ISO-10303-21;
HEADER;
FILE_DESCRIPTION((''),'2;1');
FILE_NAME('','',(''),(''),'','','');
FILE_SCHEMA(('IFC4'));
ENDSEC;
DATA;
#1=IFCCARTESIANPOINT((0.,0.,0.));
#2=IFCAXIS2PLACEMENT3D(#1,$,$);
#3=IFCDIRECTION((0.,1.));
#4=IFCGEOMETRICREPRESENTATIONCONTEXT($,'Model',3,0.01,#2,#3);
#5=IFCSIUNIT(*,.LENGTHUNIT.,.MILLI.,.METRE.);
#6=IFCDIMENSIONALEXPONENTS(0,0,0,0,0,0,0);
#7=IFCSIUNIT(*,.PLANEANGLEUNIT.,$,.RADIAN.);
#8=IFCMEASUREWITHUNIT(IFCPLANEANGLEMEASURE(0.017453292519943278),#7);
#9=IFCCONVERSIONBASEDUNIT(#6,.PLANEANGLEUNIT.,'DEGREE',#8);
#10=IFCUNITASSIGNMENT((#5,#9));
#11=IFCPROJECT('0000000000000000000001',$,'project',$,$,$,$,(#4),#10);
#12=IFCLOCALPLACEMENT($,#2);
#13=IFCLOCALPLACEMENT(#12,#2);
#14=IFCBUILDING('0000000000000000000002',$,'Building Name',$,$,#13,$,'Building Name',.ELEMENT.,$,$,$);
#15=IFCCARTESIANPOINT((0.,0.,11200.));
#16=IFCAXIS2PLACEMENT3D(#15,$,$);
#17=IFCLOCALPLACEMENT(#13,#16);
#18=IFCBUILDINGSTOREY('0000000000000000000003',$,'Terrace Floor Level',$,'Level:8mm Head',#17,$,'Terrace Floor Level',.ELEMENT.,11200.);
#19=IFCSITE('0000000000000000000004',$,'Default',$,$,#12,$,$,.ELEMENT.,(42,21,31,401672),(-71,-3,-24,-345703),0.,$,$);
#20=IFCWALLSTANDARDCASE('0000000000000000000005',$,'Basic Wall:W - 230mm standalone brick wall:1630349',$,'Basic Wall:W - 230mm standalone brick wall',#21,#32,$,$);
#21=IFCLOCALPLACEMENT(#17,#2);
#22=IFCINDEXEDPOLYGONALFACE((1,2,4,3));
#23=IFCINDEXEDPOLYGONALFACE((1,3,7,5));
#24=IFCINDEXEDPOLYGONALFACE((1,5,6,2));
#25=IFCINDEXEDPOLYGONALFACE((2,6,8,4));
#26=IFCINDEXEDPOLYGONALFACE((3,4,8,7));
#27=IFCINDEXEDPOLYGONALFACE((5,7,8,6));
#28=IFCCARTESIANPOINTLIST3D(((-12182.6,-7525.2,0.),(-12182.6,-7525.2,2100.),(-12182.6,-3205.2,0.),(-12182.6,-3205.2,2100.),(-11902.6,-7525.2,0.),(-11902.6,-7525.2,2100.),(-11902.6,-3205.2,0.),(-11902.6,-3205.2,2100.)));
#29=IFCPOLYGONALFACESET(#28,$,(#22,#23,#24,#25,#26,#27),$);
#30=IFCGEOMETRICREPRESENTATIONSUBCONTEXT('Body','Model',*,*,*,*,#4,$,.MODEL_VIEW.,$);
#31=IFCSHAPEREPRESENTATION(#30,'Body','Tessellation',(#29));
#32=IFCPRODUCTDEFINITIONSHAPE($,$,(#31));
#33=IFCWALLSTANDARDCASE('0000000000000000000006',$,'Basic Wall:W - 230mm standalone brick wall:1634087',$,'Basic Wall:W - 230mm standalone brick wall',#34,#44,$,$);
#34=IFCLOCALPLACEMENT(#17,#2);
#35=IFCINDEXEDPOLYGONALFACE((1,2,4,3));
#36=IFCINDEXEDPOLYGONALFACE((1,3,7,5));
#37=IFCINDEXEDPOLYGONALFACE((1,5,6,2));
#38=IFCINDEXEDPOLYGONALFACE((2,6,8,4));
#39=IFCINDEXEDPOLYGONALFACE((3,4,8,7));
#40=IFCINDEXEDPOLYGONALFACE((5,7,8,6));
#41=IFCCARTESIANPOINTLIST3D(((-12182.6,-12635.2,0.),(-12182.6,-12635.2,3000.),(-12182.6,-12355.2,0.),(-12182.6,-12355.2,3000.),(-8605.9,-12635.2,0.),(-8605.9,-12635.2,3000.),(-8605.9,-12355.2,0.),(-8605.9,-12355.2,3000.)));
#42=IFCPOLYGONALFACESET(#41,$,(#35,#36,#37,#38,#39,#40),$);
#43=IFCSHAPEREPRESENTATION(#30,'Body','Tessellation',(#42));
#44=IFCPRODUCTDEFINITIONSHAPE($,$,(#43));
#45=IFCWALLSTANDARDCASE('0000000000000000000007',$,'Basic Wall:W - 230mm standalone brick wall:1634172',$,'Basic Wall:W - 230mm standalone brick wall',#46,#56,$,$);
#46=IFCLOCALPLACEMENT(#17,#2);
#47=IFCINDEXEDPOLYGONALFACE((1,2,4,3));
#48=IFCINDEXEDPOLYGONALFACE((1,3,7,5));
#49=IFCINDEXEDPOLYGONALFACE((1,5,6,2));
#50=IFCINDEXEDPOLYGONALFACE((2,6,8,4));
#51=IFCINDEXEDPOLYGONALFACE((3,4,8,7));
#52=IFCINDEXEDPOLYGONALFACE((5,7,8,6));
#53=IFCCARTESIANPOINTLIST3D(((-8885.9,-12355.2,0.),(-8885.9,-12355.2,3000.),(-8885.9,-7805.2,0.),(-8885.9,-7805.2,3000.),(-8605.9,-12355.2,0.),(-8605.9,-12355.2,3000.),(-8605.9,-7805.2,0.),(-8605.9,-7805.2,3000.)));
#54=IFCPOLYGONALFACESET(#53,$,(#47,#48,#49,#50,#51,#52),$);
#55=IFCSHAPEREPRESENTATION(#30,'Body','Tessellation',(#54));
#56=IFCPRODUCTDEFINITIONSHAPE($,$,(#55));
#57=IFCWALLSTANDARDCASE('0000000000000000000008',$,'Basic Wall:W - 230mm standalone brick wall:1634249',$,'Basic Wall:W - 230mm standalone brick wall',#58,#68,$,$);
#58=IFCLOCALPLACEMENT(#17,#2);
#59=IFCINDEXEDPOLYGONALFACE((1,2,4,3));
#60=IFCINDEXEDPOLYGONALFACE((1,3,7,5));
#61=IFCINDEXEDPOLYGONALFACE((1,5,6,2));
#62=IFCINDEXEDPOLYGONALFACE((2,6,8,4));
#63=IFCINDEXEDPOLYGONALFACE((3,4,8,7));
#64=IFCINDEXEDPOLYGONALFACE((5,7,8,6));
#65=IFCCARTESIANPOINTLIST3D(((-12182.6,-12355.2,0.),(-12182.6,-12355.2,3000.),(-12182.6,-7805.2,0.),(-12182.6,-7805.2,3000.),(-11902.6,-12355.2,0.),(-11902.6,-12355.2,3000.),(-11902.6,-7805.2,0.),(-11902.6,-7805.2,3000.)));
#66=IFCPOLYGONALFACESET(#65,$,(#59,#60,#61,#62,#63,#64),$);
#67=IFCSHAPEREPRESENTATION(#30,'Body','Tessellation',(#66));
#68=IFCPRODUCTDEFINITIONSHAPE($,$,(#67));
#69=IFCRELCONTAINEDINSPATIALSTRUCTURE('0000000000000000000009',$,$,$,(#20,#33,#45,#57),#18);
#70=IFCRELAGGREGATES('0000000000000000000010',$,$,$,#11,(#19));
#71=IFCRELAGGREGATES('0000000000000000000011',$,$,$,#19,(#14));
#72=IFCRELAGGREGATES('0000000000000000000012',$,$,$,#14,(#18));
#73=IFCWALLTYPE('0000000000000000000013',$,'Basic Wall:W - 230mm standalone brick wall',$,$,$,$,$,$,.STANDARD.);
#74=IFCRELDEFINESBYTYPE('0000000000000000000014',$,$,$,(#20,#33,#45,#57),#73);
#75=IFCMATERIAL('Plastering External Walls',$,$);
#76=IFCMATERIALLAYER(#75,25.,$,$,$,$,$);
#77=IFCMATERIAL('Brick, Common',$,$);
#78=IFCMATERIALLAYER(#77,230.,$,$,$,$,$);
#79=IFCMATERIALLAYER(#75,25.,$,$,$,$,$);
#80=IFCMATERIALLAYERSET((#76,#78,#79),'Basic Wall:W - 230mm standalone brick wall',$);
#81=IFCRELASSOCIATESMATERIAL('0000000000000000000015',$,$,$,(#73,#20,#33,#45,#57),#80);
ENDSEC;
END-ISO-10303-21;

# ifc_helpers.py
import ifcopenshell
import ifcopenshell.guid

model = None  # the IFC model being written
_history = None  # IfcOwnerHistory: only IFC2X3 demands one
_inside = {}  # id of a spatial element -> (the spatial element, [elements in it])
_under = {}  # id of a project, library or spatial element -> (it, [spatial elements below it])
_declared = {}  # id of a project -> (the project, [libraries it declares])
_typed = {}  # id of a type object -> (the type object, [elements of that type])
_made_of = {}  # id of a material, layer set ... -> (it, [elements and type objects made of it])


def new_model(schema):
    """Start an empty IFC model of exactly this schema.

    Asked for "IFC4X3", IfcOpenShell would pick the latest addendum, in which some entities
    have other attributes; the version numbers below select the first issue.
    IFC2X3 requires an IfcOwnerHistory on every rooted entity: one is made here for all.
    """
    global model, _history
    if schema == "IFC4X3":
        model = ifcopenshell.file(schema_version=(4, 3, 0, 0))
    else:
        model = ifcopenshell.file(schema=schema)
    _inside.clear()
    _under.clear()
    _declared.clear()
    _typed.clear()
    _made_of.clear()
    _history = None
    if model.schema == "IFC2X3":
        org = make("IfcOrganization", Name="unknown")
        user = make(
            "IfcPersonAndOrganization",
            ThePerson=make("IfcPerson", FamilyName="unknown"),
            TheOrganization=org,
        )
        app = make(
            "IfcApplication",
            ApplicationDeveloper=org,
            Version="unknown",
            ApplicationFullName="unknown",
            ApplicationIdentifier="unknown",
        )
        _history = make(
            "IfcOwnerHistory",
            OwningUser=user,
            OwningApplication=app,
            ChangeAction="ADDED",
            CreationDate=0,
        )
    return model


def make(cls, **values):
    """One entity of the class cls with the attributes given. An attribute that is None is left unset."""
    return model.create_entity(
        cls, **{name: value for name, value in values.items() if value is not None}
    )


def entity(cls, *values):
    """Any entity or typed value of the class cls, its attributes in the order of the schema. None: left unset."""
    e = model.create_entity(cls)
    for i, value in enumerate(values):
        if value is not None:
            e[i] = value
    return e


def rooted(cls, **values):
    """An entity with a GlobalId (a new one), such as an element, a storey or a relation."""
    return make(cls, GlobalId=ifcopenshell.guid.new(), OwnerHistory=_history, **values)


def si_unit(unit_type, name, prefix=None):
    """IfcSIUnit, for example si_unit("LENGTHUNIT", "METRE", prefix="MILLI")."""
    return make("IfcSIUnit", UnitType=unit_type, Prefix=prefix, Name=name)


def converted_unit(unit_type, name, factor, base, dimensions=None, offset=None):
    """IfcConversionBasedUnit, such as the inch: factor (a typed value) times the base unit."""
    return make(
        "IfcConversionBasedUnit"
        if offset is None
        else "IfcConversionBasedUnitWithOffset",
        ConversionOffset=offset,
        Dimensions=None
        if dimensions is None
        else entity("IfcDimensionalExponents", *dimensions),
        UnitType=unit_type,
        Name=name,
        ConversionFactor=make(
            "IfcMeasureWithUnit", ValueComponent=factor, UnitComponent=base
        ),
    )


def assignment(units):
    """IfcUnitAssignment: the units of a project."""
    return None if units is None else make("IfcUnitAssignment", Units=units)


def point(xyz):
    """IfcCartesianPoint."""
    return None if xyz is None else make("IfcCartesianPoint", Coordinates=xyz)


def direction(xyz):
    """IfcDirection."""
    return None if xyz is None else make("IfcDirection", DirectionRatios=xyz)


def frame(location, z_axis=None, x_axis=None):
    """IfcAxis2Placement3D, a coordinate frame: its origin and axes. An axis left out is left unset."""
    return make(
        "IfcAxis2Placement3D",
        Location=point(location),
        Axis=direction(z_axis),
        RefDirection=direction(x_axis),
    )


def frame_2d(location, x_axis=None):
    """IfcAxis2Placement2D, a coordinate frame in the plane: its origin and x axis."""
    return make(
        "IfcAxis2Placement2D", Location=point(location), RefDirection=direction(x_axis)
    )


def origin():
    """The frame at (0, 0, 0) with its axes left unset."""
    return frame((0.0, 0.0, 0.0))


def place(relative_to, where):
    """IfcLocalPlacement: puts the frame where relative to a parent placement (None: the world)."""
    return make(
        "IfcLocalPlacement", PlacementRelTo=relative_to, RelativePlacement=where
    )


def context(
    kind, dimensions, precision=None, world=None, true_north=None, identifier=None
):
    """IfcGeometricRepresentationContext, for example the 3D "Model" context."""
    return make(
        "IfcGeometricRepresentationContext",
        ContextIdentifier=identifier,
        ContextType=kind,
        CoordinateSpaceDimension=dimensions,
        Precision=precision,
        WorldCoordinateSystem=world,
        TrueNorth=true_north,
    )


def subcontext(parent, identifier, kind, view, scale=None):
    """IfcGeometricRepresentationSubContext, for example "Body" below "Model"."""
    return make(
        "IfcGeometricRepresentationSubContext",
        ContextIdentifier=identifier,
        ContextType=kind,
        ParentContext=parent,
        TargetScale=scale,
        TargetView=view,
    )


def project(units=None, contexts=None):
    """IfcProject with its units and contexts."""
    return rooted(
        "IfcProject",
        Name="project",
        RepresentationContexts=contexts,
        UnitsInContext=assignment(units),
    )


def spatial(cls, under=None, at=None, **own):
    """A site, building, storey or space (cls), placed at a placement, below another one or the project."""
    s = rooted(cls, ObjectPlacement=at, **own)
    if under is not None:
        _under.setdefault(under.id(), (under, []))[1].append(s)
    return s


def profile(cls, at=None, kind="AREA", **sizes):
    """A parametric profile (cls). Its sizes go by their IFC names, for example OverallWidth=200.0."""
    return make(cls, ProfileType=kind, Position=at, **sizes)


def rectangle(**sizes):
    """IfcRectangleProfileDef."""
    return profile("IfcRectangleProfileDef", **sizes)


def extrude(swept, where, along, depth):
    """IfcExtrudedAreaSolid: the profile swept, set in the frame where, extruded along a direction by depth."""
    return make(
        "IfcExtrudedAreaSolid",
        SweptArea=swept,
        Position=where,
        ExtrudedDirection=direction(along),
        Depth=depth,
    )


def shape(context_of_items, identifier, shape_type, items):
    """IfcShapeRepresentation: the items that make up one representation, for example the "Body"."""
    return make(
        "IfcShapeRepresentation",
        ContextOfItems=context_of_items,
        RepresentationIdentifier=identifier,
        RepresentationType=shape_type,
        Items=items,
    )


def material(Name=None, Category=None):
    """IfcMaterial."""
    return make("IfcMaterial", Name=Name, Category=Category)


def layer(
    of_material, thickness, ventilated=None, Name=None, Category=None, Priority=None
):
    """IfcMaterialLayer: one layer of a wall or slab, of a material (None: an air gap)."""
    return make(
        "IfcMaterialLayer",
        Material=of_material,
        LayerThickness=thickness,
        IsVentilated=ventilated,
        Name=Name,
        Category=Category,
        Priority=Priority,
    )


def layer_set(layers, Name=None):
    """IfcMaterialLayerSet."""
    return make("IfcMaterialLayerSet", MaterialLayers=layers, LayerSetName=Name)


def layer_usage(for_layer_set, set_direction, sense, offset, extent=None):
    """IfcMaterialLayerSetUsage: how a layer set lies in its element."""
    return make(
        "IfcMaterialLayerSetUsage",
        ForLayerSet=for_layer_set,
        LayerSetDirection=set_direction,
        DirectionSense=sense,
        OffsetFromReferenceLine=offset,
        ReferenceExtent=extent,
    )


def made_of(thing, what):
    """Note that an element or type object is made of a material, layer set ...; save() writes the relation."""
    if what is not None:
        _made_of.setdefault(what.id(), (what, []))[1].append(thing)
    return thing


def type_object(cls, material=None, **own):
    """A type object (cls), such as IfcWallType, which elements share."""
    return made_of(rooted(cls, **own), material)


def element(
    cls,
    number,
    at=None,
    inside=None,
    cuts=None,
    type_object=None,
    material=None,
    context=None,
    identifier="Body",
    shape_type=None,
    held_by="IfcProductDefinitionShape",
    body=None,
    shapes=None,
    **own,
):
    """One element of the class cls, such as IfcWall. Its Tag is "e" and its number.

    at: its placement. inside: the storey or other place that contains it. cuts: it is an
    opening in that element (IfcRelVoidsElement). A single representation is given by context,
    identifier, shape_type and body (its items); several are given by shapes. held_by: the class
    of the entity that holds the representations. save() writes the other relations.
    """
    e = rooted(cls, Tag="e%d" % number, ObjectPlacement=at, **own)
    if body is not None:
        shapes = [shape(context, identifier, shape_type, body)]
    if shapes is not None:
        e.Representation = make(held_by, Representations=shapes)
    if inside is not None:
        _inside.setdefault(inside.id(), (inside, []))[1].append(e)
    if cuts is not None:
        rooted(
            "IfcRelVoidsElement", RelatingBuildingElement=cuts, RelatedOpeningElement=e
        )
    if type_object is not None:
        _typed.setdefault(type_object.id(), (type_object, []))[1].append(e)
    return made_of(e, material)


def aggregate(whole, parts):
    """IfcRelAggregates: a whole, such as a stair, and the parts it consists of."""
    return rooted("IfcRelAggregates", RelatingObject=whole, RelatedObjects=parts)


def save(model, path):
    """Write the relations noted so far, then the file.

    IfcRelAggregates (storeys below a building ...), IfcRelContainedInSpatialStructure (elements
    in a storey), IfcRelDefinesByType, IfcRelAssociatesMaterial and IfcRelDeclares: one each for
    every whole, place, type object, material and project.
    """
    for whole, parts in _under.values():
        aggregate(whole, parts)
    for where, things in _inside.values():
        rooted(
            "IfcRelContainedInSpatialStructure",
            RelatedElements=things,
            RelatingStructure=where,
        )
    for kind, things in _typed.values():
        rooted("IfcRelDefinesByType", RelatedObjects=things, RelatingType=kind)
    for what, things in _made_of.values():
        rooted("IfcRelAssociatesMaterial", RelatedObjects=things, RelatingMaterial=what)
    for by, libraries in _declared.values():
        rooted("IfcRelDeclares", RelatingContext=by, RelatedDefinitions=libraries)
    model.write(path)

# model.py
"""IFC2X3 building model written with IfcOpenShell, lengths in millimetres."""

from ifc_helpers import new_model, entity, si_unit, converted_unit, direction, frame, frame_2d, origin, place, context, subcontext, project, spatial, rectangle, extrude, material, layer, layer_set, layer_usage, type_object, element, save


model = new_model("IFC2X3")

# Units and contexts
model_context = context("Model", 3, precision=0.01, world=origin(), true_north=direction((0.0, 1.0)))
body_context = subcontext(model_context, "Body", "Model", "MODEL_VIEW")
ifc_project = project(units=[si_unit("LENGTHUNIT", "METRE", prefix="MILLI"), converted_unit("PLANEANGLEUNIT", "DEGREE", entity("IfcPlaneAngleMeasure", 0.017453292519943278), si_unit("PLANEANGLEUNIT", "RADIAN"), dimensions=[0, 0, 0, 0, 0, 0, 0])], contexts=[model_context])

# Site, building, storey
site_placement = place(None, origin())
site = spatial("IfcSite", under=ifc_project, at=site_placement, Name="Default", CompositionType="ELEMENT", RefLatitude=(42, 21, 31, 401672), RefLongitude=(-71, -3, -24, -345703), RefElevation=0.0)
building_placement = place(site_placement, origin())
building = spatial("IfcBuilding", under=site, at=building_placement, Name="Building Name", LongName="Building Name", CompositionType="ELEMENT")
storey_placement = place(building_placement, frame((0.0, 0.0, 11200.0)))
storey = spatial("IfcBuildingStorey", under=building, at=storey_placement, Name="Terrace Floor Level", ObjectType="Level:8mm Head", LongName="Terrace Floor Level", CompositionType="ELEMENT", Elevation=11200.0)

# Walls
ifc_material_1 = material(Name="Plastering External Walls")
ifc_layer_1 = layer(ifc_material_1, 25.0)
ifc_material_2 = material(Name="Brick, Common")
ifc_layer_2 = layer(ifc_material_2, 230.0)
ifc_layer_3 = layer(ifc_material_1, 25.0)
ifc_layer_set_1 = layer_set([ifc_layer_1, ifc_layer_2, ifc_layer_3], Name="Basic Wall:W - 230mm standalone brick wall")
wall_type = type_object("IfcWallType", Name="Basic Wall:W - 230mm standalone brick wall", PredefinedType="STANDARD", material=ifc_layer_set_1)
ifc_layer_usage_1 = layer_usage(ifc_layer_set_1, "AXIS2", "NEGATIVE", 140.0)
wall_1_placement = place(storey_placement, frame((-12042.6, -3205.2, 0.0), z_axis=(0.0, 0.0, 1.0), x_axis=(0.0, -1.0, 0.0)))
element("IfcWallStandardCase", 1, at=wall_1_placement, inside=storey, type_object=wall_type, material=ifc_layer_usage_1, Name="Basic Wall:W - 230mm standalone brick wall:1630349", ObjectType="Basic Wall:W - 230mm standalone brick wall", context=body_context, shape_type="SweptSolid", body=[
    extrude(rectangle(XDim=4320.0, YDim=280.0, at=frame_2d((2160.0, 0.0), x_axis=(-1.0, 0.0))), origin(), (0.0, 0.0, 1.0), 2100.0),
])
ifc_layer_usage_2 = layer_usage(ifc_layer_set_1, "AXIS2", "NEGATIVE", 140.0)
wall_2_placement = place(storey_placement, frame((-12182.6, -12495.2, 0.0)))
element("IfcWallStandardCase", 2, at=wall_2_placement, inside=storey, type_object=wall_type, material=ifc_layer_usage_2, Name="Basic Wall:W - 230mm standalone brick wall:1634087", ObjectType="Basic Wall:W - 230mm standalone brick wall", context=body_context, shape_type="SweptSolid", body=[
    extrude(rectangle(XDim=3576.7, YDim=280.0, at=frame_2d((1788.3, 0.0), x_axis=(-1.0, 0.0))), origin(), (0.0, 0.0, 1.0), 3000.0),
])
ifc_layer_usage_3 = layer_usage(ifc_layer_set_1, "AXIS2", "NEGATIVE", 140.0)
wall_3_placement = place(storey_placement, frame((-8745.9, -12355.2, 0.0), z_axis=(0.0, 0.0, 1.0), x_axis=(0.0, 1.0, 0.0)))
element("IfcWallStandardCase", 3, at=wall_3_placement, inside=storey, type_object=wall_type, material=ifc_layer_usage_3, Name="Basic Wall:W - 230mm standalone brick wall:1634172", ObjectType="Basic Wall:W - 230mm standalone brick wall", context=body_context, shape_type="SweptSolid", body=[
    extrude(rectangle(XDim=4550.0, YDim=280.0, at=frame_2d((2275.0, 0.0), x_axis=(-1.0, 0.0))), origin(), (0.0, 0.0, 1.0), 3000.0),
])
ifc_layer_usage_4 = layer_usage(ifc_layer_set_1, "AXIS2", "NEGATIVE", 140.0)
wall_4_placement = place(storey_placement, frame((-12042.6, -7805.2, 0.0), z_axis=(0.0, 0.0, 1.0), x_axis=(0.0, -1.0, 0.0)))
element("IfcWallStandardCase", 4, at=wall_4_placement, inside=storey, type_object=wall_type, material=ifc_layer_usage_4, Name="Basic Wall:W - 230mm standalone brick wall:1634249", ObjectType="Basic Wall:W - 230mm standalone brick wall", context=body_context, shape_type="SweptSolid", body=[
    extrude(rectangle(XDim=4550.0, YDim=280.0, at=frame_2d((2275.0, 0.0), x_axis=(-1.0, 0.0))), origin(), (0.0, 0.0, 1.0), 3000.0),
])

save(model, "model.ifc")
